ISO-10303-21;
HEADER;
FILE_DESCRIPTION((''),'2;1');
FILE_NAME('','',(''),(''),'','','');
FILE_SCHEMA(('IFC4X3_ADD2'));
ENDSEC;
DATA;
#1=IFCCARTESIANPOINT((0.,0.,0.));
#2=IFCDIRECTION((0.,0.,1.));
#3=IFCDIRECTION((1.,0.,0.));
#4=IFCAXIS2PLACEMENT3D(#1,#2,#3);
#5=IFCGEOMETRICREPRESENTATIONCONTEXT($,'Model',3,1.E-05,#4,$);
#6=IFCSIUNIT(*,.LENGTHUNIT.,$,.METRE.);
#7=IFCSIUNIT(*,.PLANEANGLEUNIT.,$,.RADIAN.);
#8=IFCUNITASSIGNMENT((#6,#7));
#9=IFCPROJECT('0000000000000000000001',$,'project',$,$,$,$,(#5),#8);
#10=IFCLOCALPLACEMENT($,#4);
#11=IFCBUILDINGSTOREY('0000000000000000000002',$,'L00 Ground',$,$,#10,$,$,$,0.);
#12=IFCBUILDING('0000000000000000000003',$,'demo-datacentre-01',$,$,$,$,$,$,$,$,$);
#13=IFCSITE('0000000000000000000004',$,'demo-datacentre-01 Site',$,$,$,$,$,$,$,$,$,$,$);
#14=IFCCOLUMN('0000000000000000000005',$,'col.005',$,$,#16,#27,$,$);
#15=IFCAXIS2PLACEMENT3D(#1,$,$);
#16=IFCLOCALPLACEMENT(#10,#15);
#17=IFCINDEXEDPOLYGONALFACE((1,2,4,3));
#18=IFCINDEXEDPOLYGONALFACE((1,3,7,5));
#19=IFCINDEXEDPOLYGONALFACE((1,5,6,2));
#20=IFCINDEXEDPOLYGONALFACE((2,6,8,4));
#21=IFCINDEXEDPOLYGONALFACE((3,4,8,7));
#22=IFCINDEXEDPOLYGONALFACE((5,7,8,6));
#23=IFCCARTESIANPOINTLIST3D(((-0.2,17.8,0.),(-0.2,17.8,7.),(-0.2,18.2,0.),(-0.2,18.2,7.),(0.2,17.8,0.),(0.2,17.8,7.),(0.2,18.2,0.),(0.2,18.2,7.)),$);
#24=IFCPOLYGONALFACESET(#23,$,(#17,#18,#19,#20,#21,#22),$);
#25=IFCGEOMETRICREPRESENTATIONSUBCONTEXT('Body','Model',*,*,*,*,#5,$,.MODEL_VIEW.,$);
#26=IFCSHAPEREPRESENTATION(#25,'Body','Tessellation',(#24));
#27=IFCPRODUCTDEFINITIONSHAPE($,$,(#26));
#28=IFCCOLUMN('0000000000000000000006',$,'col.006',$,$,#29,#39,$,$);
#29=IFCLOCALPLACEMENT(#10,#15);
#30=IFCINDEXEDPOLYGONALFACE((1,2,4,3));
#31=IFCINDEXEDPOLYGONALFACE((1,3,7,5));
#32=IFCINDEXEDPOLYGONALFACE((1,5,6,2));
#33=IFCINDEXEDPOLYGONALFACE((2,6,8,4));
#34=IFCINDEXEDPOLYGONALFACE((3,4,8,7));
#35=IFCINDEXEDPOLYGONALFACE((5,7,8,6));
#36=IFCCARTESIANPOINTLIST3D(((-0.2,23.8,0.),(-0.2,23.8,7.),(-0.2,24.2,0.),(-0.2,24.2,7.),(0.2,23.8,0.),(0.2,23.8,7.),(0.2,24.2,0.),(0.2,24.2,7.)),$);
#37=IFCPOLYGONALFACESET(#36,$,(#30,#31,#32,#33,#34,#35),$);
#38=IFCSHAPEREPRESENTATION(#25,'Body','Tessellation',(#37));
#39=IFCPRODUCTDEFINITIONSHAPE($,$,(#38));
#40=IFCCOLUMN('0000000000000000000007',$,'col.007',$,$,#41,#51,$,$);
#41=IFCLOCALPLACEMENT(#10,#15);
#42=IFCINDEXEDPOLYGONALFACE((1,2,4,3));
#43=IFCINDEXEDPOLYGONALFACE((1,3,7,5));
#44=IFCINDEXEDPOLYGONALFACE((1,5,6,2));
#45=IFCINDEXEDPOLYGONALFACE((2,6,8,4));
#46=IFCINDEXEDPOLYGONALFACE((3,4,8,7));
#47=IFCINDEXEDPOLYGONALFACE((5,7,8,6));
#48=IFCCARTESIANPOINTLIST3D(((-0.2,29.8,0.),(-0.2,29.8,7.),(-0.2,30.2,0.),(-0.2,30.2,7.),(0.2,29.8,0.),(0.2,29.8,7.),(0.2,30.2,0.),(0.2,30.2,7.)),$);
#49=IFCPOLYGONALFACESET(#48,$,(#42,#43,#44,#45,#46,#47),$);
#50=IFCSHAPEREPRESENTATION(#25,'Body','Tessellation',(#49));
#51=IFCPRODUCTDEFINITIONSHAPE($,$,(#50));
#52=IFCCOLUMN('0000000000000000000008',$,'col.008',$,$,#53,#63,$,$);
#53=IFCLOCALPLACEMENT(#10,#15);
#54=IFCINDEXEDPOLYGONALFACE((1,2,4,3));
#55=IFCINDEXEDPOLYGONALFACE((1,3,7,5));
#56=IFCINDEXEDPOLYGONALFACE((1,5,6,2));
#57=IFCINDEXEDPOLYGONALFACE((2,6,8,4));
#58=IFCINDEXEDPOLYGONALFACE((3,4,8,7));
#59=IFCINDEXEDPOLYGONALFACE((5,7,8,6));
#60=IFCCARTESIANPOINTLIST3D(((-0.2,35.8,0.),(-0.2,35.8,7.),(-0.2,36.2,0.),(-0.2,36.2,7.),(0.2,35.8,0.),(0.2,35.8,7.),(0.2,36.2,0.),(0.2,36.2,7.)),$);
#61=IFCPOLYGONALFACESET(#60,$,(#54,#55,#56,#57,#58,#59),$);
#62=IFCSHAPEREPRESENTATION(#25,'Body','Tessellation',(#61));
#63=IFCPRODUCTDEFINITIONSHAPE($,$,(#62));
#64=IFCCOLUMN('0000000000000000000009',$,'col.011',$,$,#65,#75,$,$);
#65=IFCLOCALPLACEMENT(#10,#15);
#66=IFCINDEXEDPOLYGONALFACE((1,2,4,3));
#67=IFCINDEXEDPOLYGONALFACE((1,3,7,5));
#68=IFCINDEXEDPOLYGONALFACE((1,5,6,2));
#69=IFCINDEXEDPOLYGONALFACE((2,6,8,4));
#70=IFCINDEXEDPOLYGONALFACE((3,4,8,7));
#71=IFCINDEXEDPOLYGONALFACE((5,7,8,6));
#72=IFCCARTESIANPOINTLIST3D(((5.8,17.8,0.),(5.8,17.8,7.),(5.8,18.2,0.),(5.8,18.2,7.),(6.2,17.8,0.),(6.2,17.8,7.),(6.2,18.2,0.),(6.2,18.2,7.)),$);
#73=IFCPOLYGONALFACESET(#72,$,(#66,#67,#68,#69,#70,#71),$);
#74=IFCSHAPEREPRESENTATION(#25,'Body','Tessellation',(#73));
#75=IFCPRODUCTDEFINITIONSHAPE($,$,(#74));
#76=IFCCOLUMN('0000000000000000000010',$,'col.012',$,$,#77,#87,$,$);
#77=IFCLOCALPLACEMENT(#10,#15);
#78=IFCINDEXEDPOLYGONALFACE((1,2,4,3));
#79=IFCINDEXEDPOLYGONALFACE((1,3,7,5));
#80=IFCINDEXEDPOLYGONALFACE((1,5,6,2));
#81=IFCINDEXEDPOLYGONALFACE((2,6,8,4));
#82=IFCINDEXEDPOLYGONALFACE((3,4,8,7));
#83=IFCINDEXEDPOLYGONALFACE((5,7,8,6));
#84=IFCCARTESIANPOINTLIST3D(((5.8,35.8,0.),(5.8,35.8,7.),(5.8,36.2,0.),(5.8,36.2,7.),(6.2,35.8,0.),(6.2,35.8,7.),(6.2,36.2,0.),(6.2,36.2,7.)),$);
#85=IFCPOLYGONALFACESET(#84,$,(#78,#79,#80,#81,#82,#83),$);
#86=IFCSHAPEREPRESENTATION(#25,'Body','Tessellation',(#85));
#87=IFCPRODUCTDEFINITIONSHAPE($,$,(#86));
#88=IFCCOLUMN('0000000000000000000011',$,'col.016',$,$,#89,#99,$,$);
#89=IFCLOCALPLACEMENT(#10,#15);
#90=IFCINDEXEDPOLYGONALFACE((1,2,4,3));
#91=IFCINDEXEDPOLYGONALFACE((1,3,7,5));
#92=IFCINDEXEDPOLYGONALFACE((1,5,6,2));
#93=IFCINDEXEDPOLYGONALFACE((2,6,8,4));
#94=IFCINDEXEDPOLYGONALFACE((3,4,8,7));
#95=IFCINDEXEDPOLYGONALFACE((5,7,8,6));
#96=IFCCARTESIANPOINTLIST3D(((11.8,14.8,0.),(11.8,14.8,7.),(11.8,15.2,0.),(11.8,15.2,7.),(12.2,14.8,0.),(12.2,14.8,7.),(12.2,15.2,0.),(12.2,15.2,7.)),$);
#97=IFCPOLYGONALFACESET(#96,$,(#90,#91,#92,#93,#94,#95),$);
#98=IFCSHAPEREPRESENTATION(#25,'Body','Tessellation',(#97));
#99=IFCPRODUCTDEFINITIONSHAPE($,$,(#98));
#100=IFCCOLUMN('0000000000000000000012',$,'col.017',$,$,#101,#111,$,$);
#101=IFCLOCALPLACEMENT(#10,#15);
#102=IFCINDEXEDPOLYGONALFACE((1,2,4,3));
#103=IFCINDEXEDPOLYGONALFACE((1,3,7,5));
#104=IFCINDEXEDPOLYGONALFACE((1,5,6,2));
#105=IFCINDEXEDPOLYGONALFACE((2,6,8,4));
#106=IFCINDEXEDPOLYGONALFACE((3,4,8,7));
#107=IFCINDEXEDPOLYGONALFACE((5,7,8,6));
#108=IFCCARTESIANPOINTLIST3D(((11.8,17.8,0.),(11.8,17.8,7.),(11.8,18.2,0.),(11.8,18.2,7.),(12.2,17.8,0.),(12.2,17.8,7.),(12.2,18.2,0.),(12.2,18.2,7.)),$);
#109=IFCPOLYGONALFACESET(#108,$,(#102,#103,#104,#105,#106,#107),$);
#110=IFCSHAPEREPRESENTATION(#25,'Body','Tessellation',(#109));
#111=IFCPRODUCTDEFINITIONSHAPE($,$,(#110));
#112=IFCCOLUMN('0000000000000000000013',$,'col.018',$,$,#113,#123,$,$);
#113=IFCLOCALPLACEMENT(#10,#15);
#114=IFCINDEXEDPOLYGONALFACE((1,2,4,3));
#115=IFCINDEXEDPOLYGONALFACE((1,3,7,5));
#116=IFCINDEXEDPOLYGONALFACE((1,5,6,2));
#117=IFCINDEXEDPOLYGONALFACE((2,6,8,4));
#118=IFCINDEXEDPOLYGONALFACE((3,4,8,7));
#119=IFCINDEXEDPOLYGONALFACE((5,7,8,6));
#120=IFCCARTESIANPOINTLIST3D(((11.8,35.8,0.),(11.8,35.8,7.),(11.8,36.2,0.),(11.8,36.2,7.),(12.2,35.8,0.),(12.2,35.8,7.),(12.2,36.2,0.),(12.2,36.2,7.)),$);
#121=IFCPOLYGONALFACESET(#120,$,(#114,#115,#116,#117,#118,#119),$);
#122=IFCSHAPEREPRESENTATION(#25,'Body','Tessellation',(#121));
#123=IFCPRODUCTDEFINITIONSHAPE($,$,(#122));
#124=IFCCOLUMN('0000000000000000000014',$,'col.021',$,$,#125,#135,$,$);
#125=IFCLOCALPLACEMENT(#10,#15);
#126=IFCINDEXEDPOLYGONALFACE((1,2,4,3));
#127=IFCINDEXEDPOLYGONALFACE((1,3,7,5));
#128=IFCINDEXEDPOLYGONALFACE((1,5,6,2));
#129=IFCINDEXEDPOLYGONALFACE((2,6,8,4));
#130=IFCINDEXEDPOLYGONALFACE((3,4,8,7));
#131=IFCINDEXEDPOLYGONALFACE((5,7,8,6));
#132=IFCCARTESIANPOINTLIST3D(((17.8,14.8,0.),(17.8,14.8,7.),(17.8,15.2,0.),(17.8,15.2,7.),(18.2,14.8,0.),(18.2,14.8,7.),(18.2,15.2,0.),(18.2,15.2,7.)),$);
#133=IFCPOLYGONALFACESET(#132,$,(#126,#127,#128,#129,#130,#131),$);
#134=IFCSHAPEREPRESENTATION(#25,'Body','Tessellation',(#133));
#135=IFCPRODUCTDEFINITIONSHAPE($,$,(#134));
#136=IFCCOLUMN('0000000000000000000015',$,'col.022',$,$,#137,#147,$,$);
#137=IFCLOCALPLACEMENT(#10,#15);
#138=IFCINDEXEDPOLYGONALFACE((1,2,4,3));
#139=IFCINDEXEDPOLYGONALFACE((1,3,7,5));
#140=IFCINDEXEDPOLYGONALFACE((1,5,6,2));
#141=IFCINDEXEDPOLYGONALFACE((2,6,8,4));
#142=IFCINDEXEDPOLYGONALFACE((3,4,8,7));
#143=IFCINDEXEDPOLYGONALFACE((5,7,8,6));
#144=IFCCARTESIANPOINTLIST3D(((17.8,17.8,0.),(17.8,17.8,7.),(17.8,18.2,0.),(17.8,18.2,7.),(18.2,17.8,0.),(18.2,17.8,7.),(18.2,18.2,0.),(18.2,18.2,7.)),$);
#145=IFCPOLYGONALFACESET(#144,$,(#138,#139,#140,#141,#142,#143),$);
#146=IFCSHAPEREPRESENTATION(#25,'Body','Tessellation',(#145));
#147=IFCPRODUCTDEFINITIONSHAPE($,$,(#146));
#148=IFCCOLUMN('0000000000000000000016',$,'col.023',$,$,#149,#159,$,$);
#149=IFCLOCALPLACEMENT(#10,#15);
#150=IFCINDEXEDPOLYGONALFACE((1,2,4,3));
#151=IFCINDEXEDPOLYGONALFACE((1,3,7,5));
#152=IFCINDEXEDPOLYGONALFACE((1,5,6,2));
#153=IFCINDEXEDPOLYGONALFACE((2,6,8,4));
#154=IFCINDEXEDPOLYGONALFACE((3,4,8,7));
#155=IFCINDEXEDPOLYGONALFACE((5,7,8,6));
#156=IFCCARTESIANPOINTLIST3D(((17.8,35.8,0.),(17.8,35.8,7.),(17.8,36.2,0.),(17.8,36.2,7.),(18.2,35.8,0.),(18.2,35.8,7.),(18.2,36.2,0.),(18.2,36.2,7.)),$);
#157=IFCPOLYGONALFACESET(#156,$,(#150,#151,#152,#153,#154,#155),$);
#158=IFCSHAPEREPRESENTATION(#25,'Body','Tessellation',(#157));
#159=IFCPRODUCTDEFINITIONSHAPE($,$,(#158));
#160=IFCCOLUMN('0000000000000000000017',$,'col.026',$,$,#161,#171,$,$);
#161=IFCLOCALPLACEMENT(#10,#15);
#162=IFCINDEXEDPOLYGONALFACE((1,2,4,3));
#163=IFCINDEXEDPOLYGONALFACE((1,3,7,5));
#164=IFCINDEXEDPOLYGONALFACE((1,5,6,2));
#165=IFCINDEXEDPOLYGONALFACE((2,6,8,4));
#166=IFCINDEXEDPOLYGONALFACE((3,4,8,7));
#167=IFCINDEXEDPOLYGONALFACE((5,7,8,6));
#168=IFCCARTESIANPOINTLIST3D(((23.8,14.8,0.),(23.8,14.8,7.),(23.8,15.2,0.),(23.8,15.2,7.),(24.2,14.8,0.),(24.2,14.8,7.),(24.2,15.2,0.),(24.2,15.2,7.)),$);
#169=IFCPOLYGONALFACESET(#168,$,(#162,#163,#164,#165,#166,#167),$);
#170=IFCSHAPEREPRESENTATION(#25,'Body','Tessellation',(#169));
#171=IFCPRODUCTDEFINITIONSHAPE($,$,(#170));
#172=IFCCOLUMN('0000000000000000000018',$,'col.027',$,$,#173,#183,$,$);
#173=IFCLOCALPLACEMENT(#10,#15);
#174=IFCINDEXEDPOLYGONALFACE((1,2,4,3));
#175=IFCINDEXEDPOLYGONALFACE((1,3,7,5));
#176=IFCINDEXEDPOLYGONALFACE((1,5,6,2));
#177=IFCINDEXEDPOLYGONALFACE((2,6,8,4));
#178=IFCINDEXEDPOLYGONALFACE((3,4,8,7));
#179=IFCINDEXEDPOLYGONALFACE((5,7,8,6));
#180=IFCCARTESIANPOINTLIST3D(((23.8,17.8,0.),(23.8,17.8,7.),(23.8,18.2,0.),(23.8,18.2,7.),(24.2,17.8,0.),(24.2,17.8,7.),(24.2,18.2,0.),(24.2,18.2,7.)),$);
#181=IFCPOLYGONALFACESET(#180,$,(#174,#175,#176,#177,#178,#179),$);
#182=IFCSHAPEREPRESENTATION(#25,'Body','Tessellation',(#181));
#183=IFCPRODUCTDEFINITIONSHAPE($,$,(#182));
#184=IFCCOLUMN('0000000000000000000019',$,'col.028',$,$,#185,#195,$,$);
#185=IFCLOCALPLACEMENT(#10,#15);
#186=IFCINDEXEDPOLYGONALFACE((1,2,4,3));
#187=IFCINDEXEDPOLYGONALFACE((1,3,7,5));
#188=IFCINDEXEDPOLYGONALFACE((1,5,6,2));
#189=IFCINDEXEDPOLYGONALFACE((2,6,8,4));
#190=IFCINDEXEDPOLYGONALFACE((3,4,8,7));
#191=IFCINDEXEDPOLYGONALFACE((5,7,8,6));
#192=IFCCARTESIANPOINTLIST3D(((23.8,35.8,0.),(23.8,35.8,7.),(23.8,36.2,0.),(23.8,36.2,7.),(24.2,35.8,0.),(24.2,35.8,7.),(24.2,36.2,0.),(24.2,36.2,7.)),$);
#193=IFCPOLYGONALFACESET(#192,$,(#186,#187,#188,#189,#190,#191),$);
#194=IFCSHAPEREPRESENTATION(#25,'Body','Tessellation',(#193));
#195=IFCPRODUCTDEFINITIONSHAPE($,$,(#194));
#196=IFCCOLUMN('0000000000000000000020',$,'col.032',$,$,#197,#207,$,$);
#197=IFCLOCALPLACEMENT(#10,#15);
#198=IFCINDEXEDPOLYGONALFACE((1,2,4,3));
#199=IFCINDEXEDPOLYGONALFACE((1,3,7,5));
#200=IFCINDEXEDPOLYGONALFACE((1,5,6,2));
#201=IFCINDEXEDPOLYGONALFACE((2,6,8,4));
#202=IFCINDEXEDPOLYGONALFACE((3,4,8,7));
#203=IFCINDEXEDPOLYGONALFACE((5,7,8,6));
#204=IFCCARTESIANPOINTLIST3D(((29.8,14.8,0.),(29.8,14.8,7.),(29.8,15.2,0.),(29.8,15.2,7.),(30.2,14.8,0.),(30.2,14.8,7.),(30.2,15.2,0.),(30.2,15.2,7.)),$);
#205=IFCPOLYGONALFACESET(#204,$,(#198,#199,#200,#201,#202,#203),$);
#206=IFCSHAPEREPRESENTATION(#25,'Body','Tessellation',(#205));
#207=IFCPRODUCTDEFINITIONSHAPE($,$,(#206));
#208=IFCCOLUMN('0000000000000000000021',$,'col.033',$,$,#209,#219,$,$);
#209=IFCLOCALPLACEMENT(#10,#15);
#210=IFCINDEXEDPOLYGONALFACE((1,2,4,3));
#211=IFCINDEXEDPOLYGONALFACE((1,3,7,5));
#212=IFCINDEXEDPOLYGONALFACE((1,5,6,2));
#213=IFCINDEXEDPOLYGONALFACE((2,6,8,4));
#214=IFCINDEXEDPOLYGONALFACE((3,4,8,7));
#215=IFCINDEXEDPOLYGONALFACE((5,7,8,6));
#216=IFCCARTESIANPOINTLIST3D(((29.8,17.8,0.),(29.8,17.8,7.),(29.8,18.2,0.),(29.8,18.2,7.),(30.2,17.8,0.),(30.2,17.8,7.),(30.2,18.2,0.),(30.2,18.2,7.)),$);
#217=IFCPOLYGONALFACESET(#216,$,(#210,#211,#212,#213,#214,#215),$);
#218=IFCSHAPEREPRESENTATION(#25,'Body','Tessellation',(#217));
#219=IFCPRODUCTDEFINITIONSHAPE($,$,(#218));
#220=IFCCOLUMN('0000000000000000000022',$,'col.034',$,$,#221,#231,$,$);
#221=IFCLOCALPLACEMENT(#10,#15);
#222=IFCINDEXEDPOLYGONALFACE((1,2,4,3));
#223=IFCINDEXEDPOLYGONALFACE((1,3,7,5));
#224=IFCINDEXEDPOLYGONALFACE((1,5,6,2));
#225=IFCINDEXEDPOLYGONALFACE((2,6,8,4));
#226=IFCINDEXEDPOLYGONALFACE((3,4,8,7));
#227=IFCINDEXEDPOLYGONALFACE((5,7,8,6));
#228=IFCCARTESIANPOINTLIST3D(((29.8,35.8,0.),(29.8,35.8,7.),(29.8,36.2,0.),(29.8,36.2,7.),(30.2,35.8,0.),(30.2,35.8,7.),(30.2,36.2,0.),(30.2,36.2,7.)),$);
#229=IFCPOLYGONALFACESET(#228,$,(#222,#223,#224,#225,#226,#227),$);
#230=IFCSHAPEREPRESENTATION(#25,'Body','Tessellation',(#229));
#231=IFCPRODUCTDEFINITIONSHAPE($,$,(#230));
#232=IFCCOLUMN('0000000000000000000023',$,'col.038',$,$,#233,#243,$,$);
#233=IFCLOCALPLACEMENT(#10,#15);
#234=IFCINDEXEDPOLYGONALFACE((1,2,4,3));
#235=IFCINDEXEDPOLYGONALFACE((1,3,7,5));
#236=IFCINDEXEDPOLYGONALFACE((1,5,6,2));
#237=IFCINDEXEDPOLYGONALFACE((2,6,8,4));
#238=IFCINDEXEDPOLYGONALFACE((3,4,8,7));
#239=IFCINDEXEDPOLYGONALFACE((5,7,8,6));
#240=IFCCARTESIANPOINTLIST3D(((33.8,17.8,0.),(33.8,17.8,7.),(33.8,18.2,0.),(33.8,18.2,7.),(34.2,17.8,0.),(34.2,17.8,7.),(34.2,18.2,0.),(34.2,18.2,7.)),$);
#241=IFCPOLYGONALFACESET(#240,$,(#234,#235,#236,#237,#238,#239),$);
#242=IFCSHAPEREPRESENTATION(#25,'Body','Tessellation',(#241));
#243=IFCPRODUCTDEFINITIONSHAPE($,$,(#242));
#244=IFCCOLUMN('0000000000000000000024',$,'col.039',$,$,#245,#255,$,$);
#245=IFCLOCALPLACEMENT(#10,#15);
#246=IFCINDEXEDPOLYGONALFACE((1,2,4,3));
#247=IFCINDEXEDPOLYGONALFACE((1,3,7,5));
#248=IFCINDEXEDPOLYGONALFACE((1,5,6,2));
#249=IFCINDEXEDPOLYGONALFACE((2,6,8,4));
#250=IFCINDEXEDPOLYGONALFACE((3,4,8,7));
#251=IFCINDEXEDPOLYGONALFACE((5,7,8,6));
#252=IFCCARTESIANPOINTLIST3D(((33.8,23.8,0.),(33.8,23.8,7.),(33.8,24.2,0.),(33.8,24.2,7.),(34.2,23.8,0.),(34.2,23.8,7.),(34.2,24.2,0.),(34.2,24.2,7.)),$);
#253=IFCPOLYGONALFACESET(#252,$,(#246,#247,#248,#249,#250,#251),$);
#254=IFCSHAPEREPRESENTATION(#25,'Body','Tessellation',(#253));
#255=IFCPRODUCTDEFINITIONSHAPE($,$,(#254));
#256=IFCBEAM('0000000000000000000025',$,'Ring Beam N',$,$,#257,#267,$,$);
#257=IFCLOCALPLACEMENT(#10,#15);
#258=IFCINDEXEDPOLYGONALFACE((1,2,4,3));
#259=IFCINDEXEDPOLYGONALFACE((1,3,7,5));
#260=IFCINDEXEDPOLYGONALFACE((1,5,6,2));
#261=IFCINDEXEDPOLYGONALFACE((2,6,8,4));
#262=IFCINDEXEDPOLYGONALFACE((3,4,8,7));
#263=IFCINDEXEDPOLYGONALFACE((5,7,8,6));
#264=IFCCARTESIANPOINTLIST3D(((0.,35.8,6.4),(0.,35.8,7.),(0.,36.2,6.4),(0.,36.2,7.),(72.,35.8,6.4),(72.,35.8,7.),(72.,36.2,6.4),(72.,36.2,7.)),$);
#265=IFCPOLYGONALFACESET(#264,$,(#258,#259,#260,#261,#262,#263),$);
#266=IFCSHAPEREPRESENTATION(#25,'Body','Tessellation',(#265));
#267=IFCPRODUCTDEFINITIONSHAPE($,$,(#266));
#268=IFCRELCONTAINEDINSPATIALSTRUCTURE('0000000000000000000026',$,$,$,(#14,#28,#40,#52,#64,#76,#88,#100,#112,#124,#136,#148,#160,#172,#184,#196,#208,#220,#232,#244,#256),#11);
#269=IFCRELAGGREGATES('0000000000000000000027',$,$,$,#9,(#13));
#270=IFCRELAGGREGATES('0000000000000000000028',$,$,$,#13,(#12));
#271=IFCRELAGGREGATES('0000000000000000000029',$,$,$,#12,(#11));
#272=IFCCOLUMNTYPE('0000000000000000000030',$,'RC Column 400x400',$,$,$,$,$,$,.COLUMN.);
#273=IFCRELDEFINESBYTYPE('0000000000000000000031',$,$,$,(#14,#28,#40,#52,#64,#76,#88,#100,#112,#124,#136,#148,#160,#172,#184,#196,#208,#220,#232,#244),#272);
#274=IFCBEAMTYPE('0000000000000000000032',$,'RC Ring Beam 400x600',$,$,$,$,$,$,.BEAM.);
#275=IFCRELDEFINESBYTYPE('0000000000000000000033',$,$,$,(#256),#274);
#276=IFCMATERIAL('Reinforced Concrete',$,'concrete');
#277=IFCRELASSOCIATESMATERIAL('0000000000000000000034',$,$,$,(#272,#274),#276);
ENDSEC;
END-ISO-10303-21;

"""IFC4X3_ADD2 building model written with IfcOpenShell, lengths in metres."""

from ifc_helpers import new_model, si_unit, frame, origin_with_axes, place, context, subcontext, project, spatial, rectangle, extrude, material, type_object, element, save


model = new_model("IFC4X3_ADD2")

# Units and contexts
model_context = context("Model", 3, precision=1e-05, world=origin_with_axes())
body_context = subcontext(model_context, "Body", "Model", "MODEL_VIEW")
ifc_project = project(units=[si_unit("LENGTHUNIT", "METRE"), si_unit("PLANEANGLEUNIT", "RADIAN")], contexts=[model_context])

# Site, building, storey
site = spatial("IfcSite", under=ifc_project, Name="demo-datacentre-01 Site")
building = spatial("IfcBuilding", under=site, Name="demo-datacentre-01")
storey_placement = place(None, origin_with_axes())
storey = spatial("IfcBuildingStorey", under=building, at=storey_placement, Name="L00 Ground", Elevation=0.0)

# Columns
ifc_material = material(Name="Reinforced Concrete", Category="concrete")
column_type = type_object("IfcColumnType", Name="RC Column 400x400", PredefinedType="COLUMN", material=ifc_material)
for number, where, z_axis, x_axis, name in (
    (1, (0.0, 18.0, 0.0), (0.0, 0.0, 1.0), (1.0, 0.0, 0.0), "col.005"),
    (2, (0.0, 24.0, 0.0), (0.0, 0.0, 1.0), (1.0, 0.0, 0.0), "col.006"),
    (3, (0.0, 30.0, 0.0), (0.0, 0.0, 1.0), (1.0, 0.0, 0.0), "col.007"),
    (4, (0.0, 36.0, 0.0), (0.0, 0.0, 1.0), (1.0, 0.0, 0.0), "col.008"),
    (5, (6.0, 18.0, 0.0), (0.0, 0.0, 1.0), (1.0, 0.0, 0.0), "col.011"),
    (6, (6.0, 36.0, 0.0), (0.0, 0.0, 1.0), (1.0, 0.0, 0.0), "col.012"),
    (7, (12.0, 15.0, 0.0), (0.0, 0.0, 1.0), (1.0, 0.0, 0.0), "col.016"),
    (8, (12.0, 18.0, 0.0), (0.0, 0.0, 1.0), (1.0, 0.0, 0.0), "col.017"),
    (9, (12.0, 36.0, 0.0), (0.0, 0.0, 1.0), (1.0, 0.0, 0.0), "col.018"),
    (10, (18.0, 15.0, 0.0), (0.0, 0.0, 1.0), (1.0, 0.0, 0.0), "col.021"),
    (11, (18.0, 18.0, 0.0), (0.0, 0.0, 1.0), (1.0, 0.0, 0.0), "col.022"),
    (12, (18.0, 36.0, 0.0), (0.0, 0.0, 1.0), (1.0, 0.0, 0.0), "col.023"),
    (13, (24.0, 15.0, 0.0), (0.0, 0.0, 1.0), (1.0, 0.0, 0.0), "col.026"),
    (14, (24.0, 18.0, 0.0), (0.0, 0.0, 1.0), (1.0, 0.0, 0.0), "col.027"),
    (15, (24.0, 36.0, 0.0), (0.0, 0.0, 1.0), (1.0, 0.0, 0.0), "col.028"),
    (16, (30.0, 15.0, 0.0), (0.0, 0.0, 1.0), (1.0, 0.0, 0.0), "col.032"),
    (17, (30.0, 18.0, 0.0), (0.0, 0.0, 1.0), (1.0, 0.0, 0.0), "col.033"),
    (18, (30.0, 36.0, 0.0), (0.0, 0.0, 1.0), (1.0, 0.0, 0.0), "col.034"),
    (19, (34.0, 18.0, 0.0), (0.0, 0.0, 1.0), (1.0, 0.0, 0.0), "col.038"),
    (20, (34.0, 24.0, 0.0), (0.0, 0.0, 1.0), (1.0, 0.0, 0.0), "col.039"),
):
    element("IfcColumn", number, at=place(storey_placement, frame(where, z_axis=z_axis, x_axis=x_axis)), inside=storey, type_object=column_type, Name=name, context=body_context, shape_type="SweptSolid", body=[
        extrude(rectangle(XDim=0.4, YDim=0.4), origin_with_axes(), (0.0, 0.0, 1.0), 7.0),
    ])

# Beam
beam_type = type_object("IfcBeamType", Name="RC Ring Beam 400x600", PredefinedType="BEAM", material=ifc_material)
beam_placement = place(storey_placement, frame((0.0, 36.0, 6.7), z_axis=(1.0, 0.0, 0.0), x_axis=(0.0, 1.0, 0.0)))
element("IfcBeam", 21, at=beam_placement, inside=storey, type_object=beam_type, Name="Ring Beam N", context=body_context, shape_type="SweptSolid", body=[
    extrude(rectangle(XDim=0.4, YDim=0.6), origin_with_axes(), (0.0, 0.0, 1.0), 72.0),
])

save(model, "model.ifc")
